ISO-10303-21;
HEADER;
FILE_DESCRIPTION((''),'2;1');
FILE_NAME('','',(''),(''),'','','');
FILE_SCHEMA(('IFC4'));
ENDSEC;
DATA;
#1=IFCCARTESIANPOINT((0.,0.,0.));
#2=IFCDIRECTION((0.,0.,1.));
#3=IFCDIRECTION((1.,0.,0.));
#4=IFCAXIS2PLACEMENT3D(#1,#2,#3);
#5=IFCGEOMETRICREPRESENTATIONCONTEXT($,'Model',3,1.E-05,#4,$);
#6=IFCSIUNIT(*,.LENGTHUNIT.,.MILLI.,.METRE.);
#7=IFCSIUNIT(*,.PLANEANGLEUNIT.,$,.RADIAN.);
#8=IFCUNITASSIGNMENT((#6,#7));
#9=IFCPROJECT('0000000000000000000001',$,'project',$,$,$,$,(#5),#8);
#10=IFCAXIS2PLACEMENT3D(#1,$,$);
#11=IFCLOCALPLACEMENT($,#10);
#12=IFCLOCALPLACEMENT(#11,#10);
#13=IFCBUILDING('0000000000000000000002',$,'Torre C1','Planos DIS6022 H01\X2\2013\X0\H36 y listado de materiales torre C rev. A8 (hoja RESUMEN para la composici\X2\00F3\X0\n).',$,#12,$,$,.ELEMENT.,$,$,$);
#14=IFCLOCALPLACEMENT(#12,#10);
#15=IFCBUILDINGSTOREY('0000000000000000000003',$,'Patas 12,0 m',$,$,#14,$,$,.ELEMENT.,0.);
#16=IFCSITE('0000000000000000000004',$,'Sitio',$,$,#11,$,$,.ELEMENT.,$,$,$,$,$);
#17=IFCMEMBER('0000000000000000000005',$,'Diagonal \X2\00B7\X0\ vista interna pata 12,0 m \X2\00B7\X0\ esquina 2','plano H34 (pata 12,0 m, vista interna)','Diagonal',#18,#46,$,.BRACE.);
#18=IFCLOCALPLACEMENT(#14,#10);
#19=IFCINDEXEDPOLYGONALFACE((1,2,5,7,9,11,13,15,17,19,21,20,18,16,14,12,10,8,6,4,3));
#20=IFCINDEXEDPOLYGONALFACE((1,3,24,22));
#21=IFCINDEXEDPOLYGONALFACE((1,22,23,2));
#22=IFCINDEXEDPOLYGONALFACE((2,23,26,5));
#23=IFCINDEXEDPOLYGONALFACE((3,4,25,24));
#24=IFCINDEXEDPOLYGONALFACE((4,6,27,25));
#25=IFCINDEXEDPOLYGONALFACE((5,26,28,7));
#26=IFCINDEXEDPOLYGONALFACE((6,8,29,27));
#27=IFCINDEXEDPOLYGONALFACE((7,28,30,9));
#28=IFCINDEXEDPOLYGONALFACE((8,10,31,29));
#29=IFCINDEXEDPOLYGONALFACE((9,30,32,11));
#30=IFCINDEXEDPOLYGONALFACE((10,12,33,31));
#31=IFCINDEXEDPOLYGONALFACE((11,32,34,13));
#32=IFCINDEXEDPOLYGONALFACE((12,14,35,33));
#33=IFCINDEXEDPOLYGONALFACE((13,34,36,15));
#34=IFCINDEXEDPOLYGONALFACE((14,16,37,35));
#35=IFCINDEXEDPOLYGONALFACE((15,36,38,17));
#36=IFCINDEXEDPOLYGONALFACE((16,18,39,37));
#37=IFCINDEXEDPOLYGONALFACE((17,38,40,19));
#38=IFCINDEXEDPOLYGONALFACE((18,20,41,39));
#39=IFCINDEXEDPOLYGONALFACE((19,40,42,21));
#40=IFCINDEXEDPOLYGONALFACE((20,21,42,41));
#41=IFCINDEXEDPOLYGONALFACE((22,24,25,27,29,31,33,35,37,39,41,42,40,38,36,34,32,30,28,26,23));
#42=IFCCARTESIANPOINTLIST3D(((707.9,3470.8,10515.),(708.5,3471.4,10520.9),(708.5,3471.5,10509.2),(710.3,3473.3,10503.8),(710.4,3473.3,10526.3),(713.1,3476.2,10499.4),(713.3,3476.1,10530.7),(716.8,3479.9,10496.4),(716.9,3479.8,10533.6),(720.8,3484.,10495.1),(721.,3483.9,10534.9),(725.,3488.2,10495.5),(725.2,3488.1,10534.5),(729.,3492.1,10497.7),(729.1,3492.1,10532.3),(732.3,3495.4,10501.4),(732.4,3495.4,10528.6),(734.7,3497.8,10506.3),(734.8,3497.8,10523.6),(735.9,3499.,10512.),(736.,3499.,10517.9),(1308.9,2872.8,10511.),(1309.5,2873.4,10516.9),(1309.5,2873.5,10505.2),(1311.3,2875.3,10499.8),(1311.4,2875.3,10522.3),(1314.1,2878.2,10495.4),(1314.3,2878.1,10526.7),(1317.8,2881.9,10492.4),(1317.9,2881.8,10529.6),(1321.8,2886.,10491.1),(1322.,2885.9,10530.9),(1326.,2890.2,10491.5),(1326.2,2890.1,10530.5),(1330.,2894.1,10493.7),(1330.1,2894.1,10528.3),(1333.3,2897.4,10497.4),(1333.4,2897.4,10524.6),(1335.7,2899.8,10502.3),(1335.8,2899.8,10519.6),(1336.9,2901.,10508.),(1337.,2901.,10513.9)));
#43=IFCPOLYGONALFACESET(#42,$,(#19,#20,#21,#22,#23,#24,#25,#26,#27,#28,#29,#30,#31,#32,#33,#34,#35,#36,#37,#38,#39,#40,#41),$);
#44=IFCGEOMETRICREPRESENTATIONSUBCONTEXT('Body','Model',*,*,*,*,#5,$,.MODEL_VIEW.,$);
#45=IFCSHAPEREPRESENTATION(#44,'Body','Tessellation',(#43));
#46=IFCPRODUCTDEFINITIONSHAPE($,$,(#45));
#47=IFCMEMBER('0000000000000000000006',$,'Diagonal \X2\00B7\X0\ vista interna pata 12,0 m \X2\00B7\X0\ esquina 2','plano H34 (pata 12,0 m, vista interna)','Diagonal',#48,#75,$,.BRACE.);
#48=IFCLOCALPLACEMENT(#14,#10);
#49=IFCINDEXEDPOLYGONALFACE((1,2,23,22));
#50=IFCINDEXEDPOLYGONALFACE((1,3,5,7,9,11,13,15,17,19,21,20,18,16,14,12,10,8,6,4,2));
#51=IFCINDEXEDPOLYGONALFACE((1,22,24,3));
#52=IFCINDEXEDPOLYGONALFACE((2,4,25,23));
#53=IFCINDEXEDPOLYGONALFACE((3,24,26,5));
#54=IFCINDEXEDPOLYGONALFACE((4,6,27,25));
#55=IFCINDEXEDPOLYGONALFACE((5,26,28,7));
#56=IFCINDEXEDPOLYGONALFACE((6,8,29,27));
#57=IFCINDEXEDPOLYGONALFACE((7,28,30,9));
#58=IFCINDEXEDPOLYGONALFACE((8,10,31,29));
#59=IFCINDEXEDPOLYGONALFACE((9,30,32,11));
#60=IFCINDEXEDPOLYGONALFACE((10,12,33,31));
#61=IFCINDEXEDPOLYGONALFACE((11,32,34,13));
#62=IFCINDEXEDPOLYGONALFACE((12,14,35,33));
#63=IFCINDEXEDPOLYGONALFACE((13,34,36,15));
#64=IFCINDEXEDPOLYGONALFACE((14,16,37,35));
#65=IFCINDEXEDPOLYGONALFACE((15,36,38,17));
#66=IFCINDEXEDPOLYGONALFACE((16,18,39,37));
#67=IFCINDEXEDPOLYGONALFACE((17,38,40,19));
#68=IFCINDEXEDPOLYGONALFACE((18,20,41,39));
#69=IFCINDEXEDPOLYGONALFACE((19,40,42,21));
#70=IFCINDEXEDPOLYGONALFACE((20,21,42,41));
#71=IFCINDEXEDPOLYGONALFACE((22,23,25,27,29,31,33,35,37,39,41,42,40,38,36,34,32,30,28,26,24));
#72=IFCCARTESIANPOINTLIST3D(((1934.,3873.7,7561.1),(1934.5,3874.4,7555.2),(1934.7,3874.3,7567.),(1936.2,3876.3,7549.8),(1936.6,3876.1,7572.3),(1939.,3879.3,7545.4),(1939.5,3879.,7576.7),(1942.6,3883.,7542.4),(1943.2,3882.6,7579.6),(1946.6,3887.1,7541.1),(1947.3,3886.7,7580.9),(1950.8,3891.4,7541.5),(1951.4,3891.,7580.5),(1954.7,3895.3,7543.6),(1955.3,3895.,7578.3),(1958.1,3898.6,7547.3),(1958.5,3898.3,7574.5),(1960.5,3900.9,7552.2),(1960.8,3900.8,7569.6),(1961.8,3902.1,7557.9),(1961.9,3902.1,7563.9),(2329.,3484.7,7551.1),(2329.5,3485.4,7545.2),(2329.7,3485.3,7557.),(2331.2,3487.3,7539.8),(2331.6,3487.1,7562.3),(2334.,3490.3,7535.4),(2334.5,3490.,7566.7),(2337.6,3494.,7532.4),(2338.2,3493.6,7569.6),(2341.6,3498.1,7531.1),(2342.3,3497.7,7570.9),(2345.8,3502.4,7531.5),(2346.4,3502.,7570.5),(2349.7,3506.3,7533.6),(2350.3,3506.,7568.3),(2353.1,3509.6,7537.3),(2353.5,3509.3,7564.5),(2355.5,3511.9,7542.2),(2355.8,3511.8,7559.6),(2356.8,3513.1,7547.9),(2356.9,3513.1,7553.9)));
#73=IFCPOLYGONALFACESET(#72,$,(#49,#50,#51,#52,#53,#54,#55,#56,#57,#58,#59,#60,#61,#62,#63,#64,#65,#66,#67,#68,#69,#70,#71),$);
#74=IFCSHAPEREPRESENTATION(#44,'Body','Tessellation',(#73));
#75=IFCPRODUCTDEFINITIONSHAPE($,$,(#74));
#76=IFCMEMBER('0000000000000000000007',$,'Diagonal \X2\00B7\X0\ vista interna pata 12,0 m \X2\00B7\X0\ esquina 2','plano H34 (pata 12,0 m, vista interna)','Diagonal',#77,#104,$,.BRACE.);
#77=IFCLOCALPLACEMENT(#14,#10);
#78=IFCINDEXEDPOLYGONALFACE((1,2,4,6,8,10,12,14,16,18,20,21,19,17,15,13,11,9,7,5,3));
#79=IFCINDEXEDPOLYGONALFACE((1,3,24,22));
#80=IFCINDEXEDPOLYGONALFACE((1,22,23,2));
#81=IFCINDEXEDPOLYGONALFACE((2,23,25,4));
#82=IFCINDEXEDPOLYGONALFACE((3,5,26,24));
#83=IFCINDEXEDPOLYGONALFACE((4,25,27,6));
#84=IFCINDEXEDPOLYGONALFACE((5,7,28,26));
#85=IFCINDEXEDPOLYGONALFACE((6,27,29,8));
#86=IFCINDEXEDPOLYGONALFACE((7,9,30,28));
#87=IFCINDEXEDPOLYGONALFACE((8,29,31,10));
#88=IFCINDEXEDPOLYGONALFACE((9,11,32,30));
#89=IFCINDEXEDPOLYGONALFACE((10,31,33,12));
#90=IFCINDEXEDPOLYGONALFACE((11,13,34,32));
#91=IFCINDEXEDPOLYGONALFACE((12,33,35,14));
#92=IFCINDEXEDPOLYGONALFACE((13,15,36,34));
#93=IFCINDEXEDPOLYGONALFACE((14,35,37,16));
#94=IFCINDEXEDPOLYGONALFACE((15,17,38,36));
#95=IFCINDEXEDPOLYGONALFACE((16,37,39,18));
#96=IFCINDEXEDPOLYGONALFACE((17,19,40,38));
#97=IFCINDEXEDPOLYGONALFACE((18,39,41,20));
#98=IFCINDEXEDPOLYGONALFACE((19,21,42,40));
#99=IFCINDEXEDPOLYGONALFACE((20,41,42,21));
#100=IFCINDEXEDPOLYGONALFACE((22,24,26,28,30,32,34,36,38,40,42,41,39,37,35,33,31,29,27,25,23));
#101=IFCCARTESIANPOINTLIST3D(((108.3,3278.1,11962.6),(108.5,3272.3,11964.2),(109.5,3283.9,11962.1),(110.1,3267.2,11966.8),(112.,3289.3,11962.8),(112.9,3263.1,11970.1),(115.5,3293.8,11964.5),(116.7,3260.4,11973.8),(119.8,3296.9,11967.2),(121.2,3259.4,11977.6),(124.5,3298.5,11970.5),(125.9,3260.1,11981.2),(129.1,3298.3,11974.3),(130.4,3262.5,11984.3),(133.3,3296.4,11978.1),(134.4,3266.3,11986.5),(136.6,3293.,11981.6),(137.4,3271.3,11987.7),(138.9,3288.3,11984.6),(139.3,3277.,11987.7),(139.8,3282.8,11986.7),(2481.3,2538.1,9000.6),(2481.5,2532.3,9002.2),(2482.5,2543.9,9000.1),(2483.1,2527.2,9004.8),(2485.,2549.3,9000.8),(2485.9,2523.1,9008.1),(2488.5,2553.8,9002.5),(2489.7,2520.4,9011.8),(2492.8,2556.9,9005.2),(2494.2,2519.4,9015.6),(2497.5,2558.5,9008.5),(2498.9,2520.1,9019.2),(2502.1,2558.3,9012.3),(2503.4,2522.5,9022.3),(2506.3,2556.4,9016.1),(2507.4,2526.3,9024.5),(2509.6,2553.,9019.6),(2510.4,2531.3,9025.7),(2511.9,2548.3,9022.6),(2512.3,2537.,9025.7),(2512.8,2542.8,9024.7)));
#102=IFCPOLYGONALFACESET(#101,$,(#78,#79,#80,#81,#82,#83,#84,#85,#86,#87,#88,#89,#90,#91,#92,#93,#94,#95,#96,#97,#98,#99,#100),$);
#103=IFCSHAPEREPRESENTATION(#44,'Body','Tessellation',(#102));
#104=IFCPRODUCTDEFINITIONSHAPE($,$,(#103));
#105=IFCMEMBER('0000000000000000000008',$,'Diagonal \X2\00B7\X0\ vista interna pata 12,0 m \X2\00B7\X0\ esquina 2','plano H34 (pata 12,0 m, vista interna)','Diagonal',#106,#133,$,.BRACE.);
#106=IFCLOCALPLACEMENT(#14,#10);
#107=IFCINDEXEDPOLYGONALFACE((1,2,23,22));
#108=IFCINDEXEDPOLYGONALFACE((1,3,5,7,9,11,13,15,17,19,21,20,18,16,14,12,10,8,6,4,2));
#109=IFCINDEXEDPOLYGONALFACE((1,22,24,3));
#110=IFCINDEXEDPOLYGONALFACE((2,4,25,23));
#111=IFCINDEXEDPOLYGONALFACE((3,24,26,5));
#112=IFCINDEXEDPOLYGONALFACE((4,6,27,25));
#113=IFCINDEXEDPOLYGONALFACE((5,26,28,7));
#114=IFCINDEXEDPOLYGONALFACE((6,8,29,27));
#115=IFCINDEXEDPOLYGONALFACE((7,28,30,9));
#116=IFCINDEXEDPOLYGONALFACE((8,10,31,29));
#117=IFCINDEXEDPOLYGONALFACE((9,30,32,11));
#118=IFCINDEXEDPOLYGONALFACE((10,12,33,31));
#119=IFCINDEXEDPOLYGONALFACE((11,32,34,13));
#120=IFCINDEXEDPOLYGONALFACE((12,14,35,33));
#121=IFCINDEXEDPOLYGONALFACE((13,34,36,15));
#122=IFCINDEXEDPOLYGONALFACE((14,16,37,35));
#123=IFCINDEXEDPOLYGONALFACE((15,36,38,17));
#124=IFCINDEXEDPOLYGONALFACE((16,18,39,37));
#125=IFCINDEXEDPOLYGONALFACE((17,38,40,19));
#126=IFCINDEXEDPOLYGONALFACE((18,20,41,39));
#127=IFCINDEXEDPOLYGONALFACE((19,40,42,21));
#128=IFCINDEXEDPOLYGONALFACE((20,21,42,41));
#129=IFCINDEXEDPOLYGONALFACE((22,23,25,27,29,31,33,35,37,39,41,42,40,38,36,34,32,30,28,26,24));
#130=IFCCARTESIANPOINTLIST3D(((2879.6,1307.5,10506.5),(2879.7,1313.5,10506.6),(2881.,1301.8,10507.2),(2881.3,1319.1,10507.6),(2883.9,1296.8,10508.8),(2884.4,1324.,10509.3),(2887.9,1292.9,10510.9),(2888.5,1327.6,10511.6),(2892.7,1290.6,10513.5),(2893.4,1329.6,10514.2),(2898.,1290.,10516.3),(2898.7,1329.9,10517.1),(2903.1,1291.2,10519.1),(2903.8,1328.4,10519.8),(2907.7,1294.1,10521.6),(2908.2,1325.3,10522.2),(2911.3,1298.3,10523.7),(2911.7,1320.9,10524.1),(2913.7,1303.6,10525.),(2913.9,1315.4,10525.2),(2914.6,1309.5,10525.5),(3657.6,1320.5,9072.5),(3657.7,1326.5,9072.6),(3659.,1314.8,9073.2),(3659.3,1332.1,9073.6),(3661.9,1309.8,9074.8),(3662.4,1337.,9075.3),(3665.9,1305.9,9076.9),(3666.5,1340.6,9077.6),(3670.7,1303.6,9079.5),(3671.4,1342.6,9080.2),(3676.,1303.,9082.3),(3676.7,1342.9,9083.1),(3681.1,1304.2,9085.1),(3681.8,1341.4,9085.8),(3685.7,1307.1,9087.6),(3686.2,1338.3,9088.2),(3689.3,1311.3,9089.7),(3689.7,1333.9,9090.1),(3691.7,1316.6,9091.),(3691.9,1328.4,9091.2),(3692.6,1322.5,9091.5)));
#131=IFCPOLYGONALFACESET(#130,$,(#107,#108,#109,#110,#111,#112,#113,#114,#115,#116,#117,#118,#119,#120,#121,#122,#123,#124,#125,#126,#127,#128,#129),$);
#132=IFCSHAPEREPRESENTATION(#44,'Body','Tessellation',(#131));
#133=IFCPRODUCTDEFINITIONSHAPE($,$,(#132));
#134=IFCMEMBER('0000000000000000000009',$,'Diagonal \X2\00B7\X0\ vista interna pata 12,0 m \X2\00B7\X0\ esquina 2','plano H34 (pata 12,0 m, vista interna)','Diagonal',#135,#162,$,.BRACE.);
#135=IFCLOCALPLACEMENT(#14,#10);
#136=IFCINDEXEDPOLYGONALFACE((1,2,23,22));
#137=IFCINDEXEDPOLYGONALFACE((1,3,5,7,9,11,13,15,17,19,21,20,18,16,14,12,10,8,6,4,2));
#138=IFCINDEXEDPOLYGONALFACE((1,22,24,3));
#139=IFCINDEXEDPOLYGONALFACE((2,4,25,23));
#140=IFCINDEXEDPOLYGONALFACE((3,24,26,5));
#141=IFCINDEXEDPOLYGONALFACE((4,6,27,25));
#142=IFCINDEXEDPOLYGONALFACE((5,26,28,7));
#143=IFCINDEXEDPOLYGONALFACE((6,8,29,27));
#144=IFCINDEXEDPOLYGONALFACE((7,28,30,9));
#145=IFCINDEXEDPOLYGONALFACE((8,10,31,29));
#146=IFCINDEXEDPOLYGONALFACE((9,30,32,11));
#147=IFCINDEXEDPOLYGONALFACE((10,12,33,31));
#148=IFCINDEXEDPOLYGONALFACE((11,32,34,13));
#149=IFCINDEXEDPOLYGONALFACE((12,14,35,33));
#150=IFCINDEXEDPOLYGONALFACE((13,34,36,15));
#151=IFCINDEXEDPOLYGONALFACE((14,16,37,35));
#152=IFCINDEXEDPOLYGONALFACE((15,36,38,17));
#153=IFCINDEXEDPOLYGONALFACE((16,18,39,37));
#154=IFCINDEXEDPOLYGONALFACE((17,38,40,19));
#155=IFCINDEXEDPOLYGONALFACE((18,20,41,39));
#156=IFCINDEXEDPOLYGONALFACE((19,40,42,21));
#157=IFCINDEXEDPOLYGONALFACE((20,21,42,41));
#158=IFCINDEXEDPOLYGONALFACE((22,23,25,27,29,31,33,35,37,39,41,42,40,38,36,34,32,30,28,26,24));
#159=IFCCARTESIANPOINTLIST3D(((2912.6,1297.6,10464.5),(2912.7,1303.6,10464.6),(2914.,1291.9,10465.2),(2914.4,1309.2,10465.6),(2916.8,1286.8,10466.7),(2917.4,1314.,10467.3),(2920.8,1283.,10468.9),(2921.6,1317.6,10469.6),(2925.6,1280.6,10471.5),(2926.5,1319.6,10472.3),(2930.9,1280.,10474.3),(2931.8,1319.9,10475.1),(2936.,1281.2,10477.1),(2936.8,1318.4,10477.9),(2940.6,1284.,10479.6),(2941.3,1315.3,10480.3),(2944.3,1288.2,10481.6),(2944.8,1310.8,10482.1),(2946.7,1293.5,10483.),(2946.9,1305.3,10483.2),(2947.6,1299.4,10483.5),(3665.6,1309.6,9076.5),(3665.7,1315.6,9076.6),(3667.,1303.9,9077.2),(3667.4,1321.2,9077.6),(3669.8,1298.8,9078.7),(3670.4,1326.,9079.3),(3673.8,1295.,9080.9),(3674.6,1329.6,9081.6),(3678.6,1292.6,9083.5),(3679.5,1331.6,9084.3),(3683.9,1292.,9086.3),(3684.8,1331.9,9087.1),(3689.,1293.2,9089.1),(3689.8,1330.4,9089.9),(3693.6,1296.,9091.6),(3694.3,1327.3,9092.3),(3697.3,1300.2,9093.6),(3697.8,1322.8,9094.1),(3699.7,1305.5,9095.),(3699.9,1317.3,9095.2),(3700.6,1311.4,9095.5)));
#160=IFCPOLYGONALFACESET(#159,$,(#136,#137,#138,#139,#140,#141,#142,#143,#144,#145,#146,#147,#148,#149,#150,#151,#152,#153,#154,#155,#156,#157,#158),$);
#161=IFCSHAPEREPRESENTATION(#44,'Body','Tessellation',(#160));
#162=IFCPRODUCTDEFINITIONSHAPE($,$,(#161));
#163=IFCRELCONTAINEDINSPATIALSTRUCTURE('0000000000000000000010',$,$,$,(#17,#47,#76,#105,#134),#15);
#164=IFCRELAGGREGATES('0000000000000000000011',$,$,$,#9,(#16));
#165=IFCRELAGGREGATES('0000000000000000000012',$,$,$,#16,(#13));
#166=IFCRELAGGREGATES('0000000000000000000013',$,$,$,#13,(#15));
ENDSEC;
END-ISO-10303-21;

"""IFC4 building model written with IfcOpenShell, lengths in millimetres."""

from ifc_helpers import new_model, si_unit, frame, origin, origin_with_axes, place, context, subcontext, project, spatial, circle, extrude, element, save


model = new_model("IFC4")

# Units and contexts
model_context = context("Model", 3, precision=1e-05, world=origin_with_axes())
body_context = subcontext(model_context, "Body", "Model", "MODEL_VIEW")
ifc_project = project(units=[si_unit("LENGTHUNIT", "METRE", prefix="MILLI"), si_unit("PLANEANGLEUNIT", "RADIAN")], contexts=[model_context])

# Site, building, storey
site_placement = place(None, origin())
site = spatial("IfcSite", under=ifc_project, at=site_placement, Name="Sitio", CompositionType="ELEMENT")
building_placement = place(site_placement, origin())
building = spatial("IfcBuilding", under=site, at=building_placement, Name="Torre C1", Description="Planos DIS6022 H01–H36 y listado de materiales torre C rev. A8 (hoja RESUMEN para la composición).", CompositionType="ELEMENT")
storey_placement = place(building_placement, origin())
storey = spatial("IfcBuildingStorey", under=building, at=storey_placement, Name="Patas 12,0 m", CompositionType="ELEMENT", Elevation=0.0)

# Members
member_1_placement = place(storey_placement, frame((1323.0, 2887.0, 10511.0), z_axis=(-0.708866, 0.705327, 0.004718), x_axis=(-0.705325, -0.70888, 0.00241)))
element("IfcMember", 1, at=member_1_placement, inside=storey, Name="Diagonal · vista interna pata 12,0 m · esquina 2", Description="plano H34 (pata 12,0 m, vista interna)", ObjectType="Diagonal", PredefinedType="BRACE", context=body_context, shape_type="SweptSolid", body=[
    extrude(circle(Radius=20.0), None, (0.0, 0.0, 1.0), 847.8),
])
member_2_placement = place(storey_placement, frame((2343.0, 3499.0, 7551.0), z_axis=(-0.712382, 0.701561, 0.018035), x_axis=(-0.701608, -0.712548, 0.004633)))
element("IfcMember", 2, at=member_2_placement, inside=storey, Name="Diagonal · vista interna pata 12,0 m · esquina 2", Description="plano H34 (pata 12,0 m, vista interna)", ObjectType="Diagonal", PredefinedType="BRACE", context=body_context, shape_type="SweptSolid", body=[
    extrude(circle(Radius=20.0), None, (0.0, 0.0, 1.0), 554.5),
])
member_3_placement = place(storey_placement, frame((2497.0, 2539.0, 9013.0), z_axis=(-0.613685, 0.191373, 0.766007), x_axis=(-0.364229, -0.9294, -0.059608)))
element("IfcMember", 3, at=member_3_placement, inside=storey, Name="Diagonal · vista interna pata 12,0 m · esquina 2", Description="plano H34 (pata 12,0 m, vista interna)", ObjectType="Diagonal", PredefinedType="BRACE", context=body_context, shape_type="SweptSolid", body=[
    extrude(circle(Radius=20.0), None, (0.0, 0.0, 1.0), 3866.8),
])
member_4_placement = place(storey_placement, frame((3675.0, 1323.0, 9082.0), z_axis=(-0.47686, -0.007968, 0.878943), x_axis=(-0.799548, -0.411463, -0.437516)))
element("IfcMember", 4, at=member_4_placement, inside=storey, Name="Diagonal · vista interna pata 12,0 m · esquina 2", Description="plano H34 (pata 12,0 m, vista interna)", ObjectType="Diagonal", PredefinedType="BRACE", context=body_context, shape_type="SweptSolid", body=[
    extrude(circle(Radius=20.0), None, (0.0, 0.0, 1.0), 1631.5),
])
member_5_placement = place(storey_placement, frame((3683.0, 1312.0, 9086.0), z_axis=(-0.476841, -0.007599, 0.878957), x_axis=(-0.801518, -0.406722, -0.438345)))
element("IfcMember", 5, at=member_5_placement, inside=storey, Name="Diagonal · vista interna pata 12,0 m · esquina 2", Description="plano H34 (pata 12,0 m, vista interna)", ObjectType="Diagonal", PredefinedType="BRACE", context=body_context, shape_type="SweptSolid", body=[
    extrude(circle(Radius=20.0), None, (0.0, 0.0, 1.0), 1579.1),
])

save(model, "model.ifc")
